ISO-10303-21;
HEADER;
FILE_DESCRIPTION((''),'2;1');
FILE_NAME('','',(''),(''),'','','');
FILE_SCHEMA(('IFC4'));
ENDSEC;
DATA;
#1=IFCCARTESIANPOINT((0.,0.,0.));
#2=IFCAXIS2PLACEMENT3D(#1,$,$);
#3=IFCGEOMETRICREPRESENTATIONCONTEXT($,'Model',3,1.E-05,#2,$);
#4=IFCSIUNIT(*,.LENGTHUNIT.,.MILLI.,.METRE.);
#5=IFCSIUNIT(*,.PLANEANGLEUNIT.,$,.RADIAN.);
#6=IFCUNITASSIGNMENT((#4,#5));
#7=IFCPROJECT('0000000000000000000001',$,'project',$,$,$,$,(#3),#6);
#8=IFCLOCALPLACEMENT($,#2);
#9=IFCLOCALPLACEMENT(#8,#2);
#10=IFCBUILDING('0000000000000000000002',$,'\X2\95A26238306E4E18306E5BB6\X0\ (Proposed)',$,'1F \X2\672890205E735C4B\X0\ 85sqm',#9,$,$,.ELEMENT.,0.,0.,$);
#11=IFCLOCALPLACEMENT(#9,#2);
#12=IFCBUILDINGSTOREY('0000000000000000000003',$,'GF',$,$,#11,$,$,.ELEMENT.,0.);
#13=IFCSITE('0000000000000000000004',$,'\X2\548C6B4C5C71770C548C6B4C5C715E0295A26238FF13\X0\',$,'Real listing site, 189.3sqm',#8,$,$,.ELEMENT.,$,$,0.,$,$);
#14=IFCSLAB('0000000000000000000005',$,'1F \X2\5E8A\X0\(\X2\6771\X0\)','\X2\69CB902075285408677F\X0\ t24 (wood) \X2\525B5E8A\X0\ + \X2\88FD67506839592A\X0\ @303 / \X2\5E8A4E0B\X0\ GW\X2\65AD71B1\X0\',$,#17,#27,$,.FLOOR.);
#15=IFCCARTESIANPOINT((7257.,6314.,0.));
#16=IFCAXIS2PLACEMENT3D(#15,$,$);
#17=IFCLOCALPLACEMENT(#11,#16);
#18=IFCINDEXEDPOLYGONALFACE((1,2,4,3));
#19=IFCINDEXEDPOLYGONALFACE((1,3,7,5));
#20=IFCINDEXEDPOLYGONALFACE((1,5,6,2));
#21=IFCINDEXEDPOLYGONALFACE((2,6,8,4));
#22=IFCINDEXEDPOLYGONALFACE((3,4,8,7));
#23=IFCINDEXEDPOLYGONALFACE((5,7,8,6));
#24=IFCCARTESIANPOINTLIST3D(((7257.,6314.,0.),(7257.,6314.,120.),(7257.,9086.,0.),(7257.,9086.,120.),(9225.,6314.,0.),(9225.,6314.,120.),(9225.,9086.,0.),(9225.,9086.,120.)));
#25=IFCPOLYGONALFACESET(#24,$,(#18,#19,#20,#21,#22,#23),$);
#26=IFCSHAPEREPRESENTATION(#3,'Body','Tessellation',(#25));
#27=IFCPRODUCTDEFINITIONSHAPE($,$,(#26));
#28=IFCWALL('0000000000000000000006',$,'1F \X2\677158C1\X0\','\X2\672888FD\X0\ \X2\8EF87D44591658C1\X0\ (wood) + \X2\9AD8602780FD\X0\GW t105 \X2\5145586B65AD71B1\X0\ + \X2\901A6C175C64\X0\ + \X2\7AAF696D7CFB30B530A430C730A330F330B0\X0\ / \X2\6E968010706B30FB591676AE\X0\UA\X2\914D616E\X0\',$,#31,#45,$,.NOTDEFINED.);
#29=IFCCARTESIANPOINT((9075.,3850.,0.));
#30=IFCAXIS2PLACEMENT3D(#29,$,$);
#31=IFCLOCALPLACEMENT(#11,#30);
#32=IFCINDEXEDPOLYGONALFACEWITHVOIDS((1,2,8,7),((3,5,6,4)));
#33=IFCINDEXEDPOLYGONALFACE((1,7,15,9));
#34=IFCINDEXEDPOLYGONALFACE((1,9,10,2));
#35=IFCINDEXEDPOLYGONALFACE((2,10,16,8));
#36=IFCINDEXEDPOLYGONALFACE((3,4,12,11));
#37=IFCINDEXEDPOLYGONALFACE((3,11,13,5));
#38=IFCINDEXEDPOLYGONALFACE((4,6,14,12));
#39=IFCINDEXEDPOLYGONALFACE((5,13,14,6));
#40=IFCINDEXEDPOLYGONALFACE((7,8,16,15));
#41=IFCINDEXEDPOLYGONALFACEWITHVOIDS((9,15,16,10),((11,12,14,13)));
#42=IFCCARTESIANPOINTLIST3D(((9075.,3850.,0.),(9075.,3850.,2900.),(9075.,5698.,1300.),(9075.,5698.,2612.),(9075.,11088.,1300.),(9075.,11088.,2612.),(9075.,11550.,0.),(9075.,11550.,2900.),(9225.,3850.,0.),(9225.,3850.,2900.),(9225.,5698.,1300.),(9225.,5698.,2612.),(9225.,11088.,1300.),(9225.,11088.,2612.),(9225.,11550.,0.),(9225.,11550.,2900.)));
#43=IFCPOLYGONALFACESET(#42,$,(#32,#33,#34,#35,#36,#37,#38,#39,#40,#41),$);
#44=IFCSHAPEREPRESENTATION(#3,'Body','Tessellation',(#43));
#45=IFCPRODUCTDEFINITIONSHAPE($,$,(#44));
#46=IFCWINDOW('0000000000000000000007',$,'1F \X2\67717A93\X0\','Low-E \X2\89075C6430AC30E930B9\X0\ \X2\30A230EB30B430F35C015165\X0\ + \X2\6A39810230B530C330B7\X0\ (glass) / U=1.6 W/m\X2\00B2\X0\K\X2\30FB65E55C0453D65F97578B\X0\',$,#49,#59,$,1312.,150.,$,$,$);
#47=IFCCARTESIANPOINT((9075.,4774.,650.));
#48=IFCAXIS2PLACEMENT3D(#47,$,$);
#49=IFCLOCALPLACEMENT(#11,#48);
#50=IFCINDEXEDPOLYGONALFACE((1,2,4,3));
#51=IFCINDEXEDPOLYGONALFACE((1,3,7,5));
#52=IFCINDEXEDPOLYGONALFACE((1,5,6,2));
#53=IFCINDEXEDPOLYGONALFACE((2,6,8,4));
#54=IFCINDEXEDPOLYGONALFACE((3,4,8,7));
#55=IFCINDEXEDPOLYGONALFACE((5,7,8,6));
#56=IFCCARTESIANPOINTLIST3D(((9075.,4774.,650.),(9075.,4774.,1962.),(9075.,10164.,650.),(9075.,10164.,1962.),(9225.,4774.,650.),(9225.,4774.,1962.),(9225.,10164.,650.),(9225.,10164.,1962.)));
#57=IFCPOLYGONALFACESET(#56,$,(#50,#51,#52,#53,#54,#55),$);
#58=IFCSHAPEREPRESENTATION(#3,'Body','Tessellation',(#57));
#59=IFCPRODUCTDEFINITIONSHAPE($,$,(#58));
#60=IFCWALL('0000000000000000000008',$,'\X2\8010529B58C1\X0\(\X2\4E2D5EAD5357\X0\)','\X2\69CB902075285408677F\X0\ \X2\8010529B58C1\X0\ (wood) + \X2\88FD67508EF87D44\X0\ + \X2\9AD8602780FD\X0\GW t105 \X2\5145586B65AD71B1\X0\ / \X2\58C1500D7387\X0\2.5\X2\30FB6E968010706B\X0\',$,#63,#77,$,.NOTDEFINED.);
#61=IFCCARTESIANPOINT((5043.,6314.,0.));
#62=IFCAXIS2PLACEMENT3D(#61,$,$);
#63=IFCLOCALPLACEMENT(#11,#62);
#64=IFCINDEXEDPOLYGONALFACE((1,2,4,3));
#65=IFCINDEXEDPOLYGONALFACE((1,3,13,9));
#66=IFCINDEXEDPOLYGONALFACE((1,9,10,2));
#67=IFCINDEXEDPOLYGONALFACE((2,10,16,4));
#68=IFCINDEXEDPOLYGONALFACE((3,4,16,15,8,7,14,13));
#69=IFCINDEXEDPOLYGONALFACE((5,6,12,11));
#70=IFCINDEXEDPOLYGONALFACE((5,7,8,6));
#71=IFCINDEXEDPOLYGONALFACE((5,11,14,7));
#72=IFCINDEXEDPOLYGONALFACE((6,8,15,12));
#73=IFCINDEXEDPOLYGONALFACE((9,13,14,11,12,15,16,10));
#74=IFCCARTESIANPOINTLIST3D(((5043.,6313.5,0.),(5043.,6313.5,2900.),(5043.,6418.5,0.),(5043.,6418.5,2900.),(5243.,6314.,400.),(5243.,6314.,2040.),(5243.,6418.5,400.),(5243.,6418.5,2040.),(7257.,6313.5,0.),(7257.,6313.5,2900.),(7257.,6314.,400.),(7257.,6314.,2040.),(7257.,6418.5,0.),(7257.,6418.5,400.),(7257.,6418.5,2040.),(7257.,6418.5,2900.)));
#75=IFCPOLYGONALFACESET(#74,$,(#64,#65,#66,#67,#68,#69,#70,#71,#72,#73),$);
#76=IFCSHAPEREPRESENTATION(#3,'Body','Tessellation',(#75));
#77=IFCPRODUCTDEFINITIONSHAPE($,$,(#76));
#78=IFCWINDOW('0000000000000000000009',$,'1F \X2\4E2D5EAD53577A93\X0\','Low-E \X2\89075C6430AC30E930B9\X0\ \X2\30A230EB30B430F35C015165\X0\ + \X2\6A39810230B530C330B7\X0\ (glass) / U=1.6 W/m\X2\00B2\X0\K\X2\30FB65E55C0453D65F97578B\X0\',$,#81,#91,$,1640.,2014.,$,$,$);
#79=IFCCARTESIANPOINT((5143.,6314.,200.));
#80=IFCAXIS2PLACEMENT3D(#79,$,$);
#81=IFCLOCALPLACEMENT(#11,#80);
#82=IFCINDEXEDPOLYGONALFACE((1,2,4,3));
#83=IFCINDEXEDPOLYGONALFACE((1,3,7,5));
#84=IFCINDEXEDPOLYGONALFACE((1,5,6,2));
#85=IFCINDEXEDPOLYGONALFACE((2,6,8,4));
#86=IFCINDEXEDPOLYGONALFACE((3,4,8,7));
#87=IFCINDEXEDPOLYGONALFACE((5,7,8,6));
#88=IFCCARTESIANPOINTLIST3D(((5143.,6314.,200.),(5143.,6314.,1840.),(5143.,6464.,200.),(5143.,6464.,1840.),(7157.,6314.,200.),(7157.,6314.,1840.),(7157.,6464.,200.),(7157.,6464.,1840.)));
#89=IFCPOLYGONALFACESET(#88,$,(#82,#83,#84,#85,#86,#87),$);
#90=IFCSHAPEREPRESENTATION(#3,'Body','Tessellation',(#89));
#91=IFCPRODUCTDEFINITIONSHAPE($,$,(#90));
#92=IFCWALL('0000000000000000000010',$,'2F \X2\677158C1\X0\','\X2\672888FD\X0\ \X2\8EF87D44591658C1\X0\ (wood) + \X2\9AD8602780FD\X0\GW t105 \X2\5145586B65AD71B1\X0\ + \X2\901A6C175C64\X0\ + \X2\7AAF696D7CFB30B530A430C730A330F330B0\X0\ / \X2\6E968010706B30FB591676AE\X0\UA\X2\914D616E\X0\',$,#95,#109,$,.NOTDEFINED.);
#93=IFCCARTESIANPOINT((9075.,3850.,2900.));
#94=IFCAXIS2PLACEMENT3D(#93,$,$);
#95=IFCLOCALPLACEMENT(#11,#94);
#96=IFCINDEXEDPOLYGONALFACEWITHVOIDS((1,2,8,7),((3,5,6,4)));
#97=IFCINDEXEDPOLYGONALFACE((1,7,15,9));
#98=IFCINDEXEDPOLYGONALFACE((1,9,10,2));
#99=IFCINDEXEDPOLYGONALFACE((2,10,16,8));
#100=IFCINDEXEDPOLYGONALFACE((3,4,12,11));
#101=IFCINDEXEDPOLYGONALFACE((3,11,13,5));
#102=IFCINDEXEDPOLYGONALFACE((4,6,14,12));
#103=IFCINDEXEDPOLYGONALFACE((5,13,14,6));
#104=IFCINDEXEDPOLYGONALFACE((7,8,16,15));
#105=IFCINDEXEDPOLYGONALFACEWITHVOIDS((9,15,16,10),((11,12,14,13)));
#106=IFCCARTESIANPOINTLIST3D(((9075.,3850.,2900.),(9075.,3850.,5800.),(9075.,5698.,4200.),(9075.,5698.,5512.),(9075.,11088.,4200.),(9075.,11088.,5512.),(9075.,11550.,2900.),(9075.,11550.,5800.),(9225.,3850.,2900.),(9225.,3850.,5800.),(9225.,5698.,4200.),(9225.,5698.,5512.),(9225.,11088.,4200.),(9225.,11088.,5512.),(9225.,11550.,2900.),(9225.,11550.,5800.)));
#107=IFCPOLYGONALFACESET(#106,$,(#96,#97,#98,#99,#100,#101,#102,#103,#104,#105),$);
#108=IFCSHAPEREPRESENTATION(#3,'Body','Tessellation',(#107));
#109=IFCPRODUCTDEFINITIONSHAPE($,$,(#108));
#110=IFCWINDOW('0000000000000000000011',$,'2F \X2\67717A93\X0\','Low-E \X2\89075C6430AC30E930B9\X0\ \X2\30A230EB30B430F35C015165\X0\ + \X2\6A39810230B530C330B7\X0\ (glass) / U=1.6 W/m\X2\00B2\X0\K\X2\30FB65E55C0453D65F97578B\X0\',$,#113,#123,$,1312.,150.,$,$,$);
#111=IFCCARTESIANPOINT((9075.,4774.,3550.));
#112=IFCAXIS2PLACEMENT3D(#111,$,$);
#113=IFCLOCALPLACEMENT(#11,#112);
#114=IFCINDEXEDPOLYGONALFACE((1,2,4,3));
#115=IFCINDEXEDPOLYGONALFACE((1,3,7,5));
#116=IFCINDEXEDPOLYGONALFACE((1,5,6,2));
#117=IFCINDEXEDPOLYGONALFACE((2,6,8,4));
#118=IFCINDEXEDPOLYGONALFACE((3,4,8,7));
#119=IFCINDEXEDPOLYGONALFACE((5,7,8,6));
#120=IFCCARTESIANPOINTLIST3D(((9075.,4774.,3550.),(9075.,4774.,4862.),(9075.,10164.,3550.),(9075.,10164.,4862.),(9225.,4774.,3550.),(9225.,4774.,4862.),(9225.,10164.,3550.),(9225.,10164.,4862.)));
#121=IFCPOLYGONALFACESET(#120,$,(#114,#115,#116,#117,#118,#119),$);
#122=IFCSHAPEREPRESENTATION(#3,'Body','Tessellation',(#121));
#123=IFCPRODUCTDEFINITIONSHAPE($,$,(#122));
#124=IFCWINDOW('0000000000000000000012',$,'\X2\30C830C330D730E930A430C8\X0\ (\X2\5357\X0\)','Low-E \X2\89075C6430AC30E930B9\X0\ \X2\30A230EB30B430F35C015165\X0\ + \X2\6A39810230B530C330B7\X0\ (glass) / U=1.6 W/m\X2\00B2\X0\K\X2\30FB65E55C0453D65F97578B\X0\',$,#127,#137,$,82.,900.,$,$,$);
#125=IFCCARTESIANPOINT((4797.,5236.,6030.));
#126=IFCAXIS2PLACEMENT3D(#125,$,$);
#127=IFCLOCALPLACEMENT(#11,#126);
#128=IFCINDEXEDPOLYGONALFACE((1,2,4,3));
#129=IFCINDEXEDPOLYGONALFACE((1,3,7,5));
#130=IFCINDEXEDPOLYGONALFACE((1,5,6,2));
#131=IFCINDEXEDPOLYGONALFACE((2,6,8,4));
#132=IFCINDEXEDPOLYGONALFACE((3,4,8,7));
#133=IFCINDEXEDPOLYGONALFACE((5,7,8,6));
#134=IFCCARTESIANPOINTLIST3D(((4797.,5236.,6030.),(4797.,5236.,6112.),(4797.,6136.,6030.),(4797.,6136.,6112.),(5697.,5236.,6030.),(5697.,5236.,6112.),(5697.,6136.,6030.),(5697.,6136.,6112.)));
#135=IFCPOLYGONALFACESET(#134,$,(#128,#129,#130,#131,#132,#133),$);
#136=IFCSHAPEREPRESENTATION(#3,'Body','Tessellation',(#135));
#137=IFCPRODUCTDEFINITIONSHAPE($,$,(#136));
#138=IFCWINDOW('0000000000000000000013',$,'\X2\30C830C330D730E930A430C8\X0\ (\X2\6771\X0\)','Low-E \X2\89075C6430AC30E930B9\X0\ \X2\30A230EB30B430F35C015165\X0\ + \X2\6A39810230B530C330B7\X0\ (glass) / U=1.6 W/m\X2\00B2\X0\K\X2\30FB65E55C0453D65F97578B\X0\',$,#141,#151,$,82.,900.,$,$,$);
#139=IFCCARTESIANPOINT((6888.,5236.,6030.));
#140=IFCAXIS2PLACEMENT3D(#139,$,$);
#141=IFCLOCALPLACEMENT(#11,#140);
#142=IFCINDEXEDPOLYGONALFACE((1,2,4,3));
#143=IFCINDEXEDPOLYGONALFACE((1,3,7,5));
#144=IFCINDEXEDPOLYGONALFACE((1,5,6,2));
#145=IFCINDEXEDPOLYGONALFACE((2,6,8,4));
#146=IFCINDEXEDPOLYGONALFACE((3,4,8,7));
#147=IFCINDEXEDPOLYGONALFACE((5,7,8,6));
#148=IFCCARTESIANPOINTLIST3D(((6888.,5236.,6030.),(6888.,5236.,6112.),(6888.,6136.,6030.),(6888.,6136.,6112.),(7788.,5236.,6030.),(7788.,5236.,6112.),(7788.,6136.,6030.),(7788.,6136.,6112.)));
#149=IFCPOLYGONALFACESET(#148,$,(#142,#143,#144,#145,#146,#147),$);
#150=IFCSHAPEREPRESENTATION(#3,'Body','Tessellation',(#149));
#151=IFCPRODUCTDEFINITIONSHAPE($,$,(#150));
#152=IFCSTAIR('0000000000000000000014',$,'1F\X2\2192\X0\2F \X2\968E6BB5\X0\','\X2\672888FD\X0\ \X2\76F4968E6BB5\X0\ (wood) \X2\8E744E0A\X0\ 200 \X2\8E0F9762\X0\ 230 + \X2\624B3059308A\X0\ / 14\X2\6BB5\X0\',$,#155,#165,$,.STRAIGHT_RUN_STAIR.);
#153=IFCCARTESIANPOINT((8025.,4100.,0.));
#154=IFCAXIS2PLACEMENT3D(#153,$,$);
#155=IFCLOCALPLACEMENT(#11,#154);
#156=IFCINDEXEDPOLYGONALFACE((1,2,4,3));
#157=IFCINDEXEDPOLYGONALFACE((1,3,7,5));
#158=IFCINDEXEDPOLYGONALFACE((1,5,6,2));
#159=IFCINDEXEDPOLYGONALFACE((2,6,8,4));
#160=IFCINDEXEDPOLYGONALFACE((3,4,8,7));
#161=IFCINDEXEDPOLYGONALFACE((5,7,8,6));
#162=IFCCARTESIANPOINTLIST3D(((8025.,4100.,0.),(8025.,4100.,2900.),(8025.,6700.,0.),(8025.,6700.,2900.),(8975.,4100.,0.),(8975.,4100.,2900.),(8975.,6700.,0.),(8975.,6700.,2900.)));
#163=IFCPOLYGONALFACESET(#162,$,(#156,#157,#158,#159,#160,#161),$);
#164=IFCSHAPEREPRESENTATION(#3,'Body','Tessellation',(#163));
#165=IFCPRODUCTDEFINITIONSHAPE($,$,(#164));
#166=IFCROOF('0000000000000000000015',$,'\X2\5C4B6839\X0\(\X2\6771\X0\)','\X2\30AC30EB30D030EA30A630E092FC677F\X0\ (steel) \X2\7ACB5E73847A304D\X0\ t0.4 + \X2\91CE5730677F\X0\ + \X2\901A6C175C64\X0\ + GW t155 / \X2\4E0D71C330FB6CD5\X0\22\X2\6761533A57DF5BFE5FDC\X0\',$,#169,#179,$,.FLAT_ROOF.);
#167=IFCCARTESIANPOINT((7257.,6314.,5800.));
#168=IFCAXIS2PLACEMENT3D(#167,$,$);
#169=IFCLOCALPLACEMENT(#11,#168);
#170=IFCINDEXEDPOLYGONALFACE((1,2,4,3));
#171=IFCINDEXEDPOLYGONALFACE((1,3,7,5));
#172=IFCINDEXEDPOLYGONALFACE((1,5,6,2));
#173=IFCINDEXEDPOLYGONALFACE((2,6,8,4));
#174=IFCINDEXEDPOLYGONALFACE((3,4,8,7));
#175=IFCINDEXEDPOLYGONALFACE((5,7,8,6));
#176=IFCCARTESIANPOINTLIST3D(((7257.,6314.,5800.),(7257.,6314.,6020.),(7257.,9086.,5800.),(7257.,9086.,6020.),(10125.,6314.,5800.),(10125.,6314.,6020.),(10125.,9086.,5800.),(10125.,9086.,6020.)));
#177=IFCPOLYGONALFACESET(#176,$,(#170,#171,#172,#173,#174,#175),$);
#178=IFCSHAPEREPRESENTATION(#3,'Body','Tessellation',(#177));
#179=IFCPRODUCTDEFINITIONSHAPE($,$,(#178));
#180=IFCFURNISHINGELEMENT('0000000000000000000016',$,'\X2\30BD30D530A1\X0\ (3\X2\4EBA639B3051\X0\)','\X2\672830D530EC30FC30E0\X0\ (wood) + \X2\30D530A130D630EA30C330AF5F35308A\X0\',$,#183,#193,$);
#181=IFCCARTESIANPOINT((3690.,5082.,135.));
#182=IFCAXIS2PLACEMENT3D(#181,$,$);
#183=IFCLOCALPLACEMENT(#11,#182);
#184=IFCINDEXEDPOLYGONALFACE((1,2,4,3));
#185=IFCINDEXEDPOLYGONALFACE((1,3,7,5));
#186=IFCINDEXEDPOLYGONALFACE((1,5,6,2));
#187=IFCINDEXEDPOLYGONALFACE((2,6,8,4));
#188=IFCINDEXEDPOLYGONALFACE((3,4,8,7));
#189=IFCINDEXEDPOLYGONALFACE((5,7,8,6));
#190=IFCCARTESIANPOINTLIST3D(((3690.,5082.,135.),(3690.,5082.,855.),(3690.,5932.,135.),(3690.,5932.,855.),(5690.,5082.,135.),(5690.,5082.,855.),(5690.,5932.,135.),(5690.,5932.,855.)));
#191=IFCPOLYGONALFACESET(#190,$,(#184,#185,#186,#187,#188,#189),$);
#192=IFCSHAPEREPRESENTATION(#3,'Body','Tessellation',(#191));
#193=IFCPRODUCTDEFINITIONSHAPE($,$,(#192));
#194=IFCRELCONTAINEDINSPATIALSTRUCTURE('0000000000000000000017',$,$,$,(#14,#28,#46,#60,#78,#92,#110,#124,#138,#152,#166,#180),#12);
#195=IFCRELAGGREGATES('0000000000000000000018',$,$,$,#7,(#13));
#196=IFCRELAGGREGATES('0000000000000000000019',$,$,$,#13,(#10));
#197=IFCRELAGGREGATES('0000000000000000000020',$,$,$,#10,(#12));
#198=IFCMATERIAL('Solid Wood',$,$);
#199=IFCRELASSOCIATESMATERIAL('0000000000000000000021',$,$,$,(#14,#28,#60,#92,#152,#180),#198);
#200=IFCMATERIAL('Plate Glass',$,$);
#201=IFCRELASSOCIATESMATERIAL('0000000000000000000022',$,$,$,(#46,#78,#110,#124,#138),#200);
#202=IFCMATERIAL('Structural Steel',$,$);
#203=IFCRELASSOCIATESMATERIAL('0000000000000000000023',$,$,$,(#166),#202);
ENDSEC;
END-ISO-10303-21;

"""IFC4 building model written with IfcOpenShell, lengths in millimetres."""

from ifc_helpers import new_model, si_unit, frame, frame_2d, origin, place, context, project, spatial, rectangle, extrude, material, element, fill, save


model = new_model("IFC4")

# Units and contexts
model_context = context("Model", 3, precision=1e-05, world=origin())
ifc_project = project(units=[si_unit("LENGTHUNIT", "METRE", prefix="MILLI"), si_unit("PLANEANGLEUNIT", "RADIAN")], contexts=[model_context])

# Site, building, storey
site_placement = place(None, origin())
site = spatial("IfcSite", under=ifc_project, at=site_placement, Name="和歌山県和歌山市関戸３", ObjectType="Real listing site, 189.3sqm", CompositionType="ELEMENT", RefElevation=0.0)
building_placement = place(site_placement, origin())
building = spatial("IfcBuilding", under=site, at=building_placement, Name="関戸の丘の家 (Proposed)", ObjectType="1F 木造平屋 85sqm", CompositionType="ELEMENT", ElevationOfRefHeight=0.0, ElevationOfTerrain=0.0)
storey_placement = place(building_placement, origin())
storey = spatial("IfcBuildingStorey", under=building, at=storey_placement, Name="GF", CompositionType="ELEMENT", Elevation=0.0)

# Slab
ifc_material_1 = material(Name="Solid Wood")
slab_placement = place(storey_placement, frame((7257.0, 6314.0, 0.0)))
element("IfcSlab", 1, at=slab_placement, inside=storey, material=ifc_material_1, Name="1F 床(東)", Description="構造用合板 t24 (wood) 剛床 + 製材根太 @303 / 床下 GW断熱", PredefinedType="FLOOR", context=model_context, shape_type="SweptSolid", body=[
    extrude(rectangle(XDim=1968.0, YDim=2772.0, at=frame_2d((984.0, 1386.0))), frame((7257.0, 6314.0, 0.0)), (0.0, 0.0, 1.0), 120.0),
])

# Walls, openings, windows
wall_1_placement = place(storey_placement, frame((9075.0, 3850.0, 0.0)))
wall_1 = element("IfcWall", 2, at=wall_1_placement, inside=storey, material=ifc_material_1, Name="1F 東壁", Description="木製 軸組外壁 (wood) + 高性能GW t105 充填断熱 + 通気層 + 窯業系サイディング / 準耐火・外皮UA配慮", PredefinedType="NOTDEFINED", context=model_context, shape_type="SweptSolid", body=[
    extrude(rectangle(XDim=150.0, YDim=7700.0, at=frame_2d((75.0, 3850.0))), frame((9075.0, 3850.0, 0.0)), (0.0, 0.0, 1.0), 2900.0),
])
opening_1_placement = place(storey_placement, frame((9075.0, 4774.0, 650.0)))
opening_1 = element("IfcOpeningElement", 3, at=opening_1_placement, cuts=wall_1, PredefinedType="NOTDEFINED", context=model_context, shape_type="SweptSolid", body=[
    extrude(rectangle(XDim=150.0, YDim=5390.0, at=frame_2d((75.0, 2695.0))), frame((9075.0, 4774.0, 650.0)), (0.0, 0.0, 1.0), 1312.0),
])
ifc_material_2 = material(Name="Plate Glass")
window_1_placement = place(storey_placement, frame((9075.0, 4774.0, 650.0)))
window_1 = element("IfcWindow", 4, at=window_1_placement, inside=storey, material=ifc_material_2, Name="1F 東窓", Description="Low-E 複層ガラス アルゴン封入 + 樹脂サッシ (glass) / U=1.6 W/m²K・日射取得型", OverallHeight=1312.0, OverallWidth=150.0, context=model_context, shape_type="SweptSolid", body=[
    extrude(rectangle(XDim=150.0, YDim=5390.0, at=frame_2d((75.0, 2695.0))), frame((9075.0, 4774.0, 650.0)), (0.0, 0.0, 1.0), 1312.0),
])
fill(opening_1, window_1)
wall_2_placement = place(storey_placement, frame((5043.0, 6314.0, 0.0)))
wall_2 = element("IfcWall", 5, at=wall_2_placement, inside=storey, material=ifc_material_1, Name="耐力壁(中庭南)", Description="構造用合板 耐力壁 (wood) + 製材軸組 + 高性能GW t105 充填断熱 / 壁倍率2.5・準耐火", PredefinedType="NOTDEFINED", context=model_context, shape_type="SweptSolid", body=[
    extrude(rectangle(XDim=2214.0, YDim=105.0, at=frame_2d((1107.0, 52.0))), frame((5043.0, 6314.0, 0.0)), (0.0, 0.0, 1.0), 2900.0),
])
opening_2_placement = place(storey_placement, frame((5143.0, 6314.0, 200.0)))
opening_2 = element("IfcOpeningElement", 6, at=opening_2_placement, cuts=wall_2, PredefinedType="NOTDEFINED", context=model_context, shape_type="SweptSolid", body=[
    extrude(rectangle(XDim=2014.0, YDim=150.0, at=frame_2d((1007.0, 75.0))), frame((5143.0, 6314.0, 200.0)), (0.0, 0.0, 1.0), 1640.0),
])
window_2_placement = place(storey_placement, frame((5143.0, 6314.0, 200.0)))
window_2 = element("IfcWindow", 7, at=window_2_placement, inside=storey, material=ifc_material_2, Name="1F 中庭南窓", Description="Low-E 複層ガラス アルゴン封入 + 樹脂サッシ (glass) / U=1.6 W/m²K・日射取得型", OverallHeight=1640.0, OverallWidth=2014.0, context=model_context, shape_type="SweptSolid", body=[
    extrude(rectangle(XDim=2014.0, YDim=150.0, at=frame_2d((1007.0, 75.0))), frame((5143.0, 6314.0, 200.0)), (0.0, 0.0, 1.0), 1640.0),
])
fill(opening_2, window_2)

# Wall, opening, window
wall_3_placement = place(storey_placement, frame((9075.0, 3850.0, 2900.0)))
wall_3 = element("IfcWall", 8, at=wall_3_placement, inside=storey, material=ifc_material_1, Name="2F 東壁", Description="木製 軸組外壁 (wood) + 高性能GW t105 充填断熱 + 通気層 + 窯業系サイディング / 準耐火・外皮UA配慮", PredefinedType="NOTDEFINED", context=model_context, shape_type="SweptSolid", body=[
    extrude(rectangle(XDim=150.0, YDim=7700.0, at=frame_2d((75.0, 3850.0))), frame((9075.0, 3850.0, 2900.0)), (0.0, 0.0, 1.0), 2900.0),
])
opening_3_placement = place(storey_placement, frame((9075.0, 4774.0, 3550.0)))
opening_3 = element("IfcOpeningElement", 9, at=opening_3_placement, cuts=wall_3, PredefinedType="NOTDEFINED", context=model_context, shape_type="SweptSolid", body=[
    extrude(rectangle(XDim=150.0, YDim=5390.0, at=frame_2d((75.0, 2695.0))), frame((9075.0, 4774.0, 3550.0)), (0.0, 0.0, 1.0), 1312.0),
])
window_3_placement = place(storey_placement, frame((9075.0, 4774.0, 3550.0)))
window_3 = element("IfcWindow", 10, at=window_3_placement, inside=storey, material=ifc_material_2, Name="2F 東窓", Description="Low-E 複層ガラス アルゴン封入 + 樹脂サッシ (glass) / U=1.6 W/m²K・日射取得型", OverallHeight=1312.0, OverallWidth=150.0, context=model_context, shape_type="SweptSolid", body=[
    extrude(rectangle(XDim=150.0, YDim=5390.0, at=frame_2d((75.0, 2695.0))), frame((9075.0, 4774.0, 3550.0)), (0.0, 0.0, 1.0), 1312.0),
])
fill(opening_3, window_3)

# Windows
window_4_placement = place(storey_placement, frame((4797.0, 5236.0, 6030.0)))
element("IfcWindow", 11, at=window_4_placement, inside=storey, material=ifc_material_2, Name="トップライト (南)", Description="Low-E 複層ガラス アルゴン封入 + 樹脂サッシ (glass) / U=1.6 W/m²K・日射取得型", OverallHeight=82.0, OverallWidth=900.0, context=model_context, shape_type="SweptSolid", body=[
    extrude(rectangle(XDim=900.0, YDim=900.0, at=frame_2d((450.0, 450.0))), frame((4797.0, 5236.0, 6030.0)), (0.0, 0.0, 1.0), 82.0),
])
window_5_placement = place(storey_placement, frame((6888.0, 5236.0, 6030.0)))
element("IfcWindow", 12, at=window_5_placement, inside=storey, material=ifc_material_2, Name="トップライト (東)", Description="Low-E 複層ガラス アルゴン封入 + 樹脂サッシ (glass) / U=1.6 W/m²K・日射取得型", OverallHeight=82.0, OverallWidth=900.0, context=model_context, shape_type="SweptSolid", body=[
    extrude(rectangle(XDim=900.0, YDim=900.0, at=frame_2d((450.0, 450.0))), frame((6888.0, 5236.0, 6030.0)), (0.0, 0.0, 1.0), 82.0),
])

# Stair
stair_placement = place(storey_placement, frame((8025.0, 4100.0, 0.0)))
element("IfcStair", 13, at=stair_placement, inside=storey, material=ifc_material_1, Name="1F→2F 階段", Description="木製 直階段 (wood) 蹴上 200 踏面 230 + 手すり / 14段", PredefinedType="STRAIGHT_RUN_STAIR", context=model_context, shape_type="SweptSolid", body=[
    extrude(rectangle(XDim=950.0, YDim=2600.0, at=frame_2d((475.0, 1300.0))), frame((8025.0, 4100.0, 0.0)), (0.0, 0.0, 1.0), 2900.0),
])

# Roof
ifc_material_3 = material(Name="Structural Steel")
roof_placement = place(storey_placement, frame((7257.0, 6314.0, 5800.0)))
element("IfcRoof", 14, at=roof_placement, inside=storey, material=ifc_material_3, Name="屋根(東)", Description="ガルバリウム鋼板 (steel) 立平葺き t0.4 + 野地板 + 通気層 + GW t155 / 不燃・法22条区域対応", PredefinedType="FLAT_ROOF", context=model_context, shape_type="SweptSolid", body=[
    extrude(rectangle(XDim=2868.0, YDim=2772.0, at=frame_2d((1434.0, 1386.0))), frame((7257.0, 6314.0, 5800.0)), (0.0, 0.0, 1.0), 220.0),
])

# Furnishing element
furnishing_1_placement = place(storey_placement, frame((3690.0, 5082.0, 135.0)))
element("IfcFurnishingElement", 15, at=furnishing_1_placement, inside=storey, material=ifc_material_1, Name="ソファ (3人掛け)", Description="木フレーム (wood) + ファブリック張り", context=model_context, shape_type="SweptSolid", body=[
    extrude(rectangle(XDim=2000.0, YDim=850.0, at=frame_2d((1000.0, 425.0))), frame((3690.0, 5082.0, 135.0)), (0.0, 0.0, 1.0), 720.0),
])

save(model, "model.ifc")
